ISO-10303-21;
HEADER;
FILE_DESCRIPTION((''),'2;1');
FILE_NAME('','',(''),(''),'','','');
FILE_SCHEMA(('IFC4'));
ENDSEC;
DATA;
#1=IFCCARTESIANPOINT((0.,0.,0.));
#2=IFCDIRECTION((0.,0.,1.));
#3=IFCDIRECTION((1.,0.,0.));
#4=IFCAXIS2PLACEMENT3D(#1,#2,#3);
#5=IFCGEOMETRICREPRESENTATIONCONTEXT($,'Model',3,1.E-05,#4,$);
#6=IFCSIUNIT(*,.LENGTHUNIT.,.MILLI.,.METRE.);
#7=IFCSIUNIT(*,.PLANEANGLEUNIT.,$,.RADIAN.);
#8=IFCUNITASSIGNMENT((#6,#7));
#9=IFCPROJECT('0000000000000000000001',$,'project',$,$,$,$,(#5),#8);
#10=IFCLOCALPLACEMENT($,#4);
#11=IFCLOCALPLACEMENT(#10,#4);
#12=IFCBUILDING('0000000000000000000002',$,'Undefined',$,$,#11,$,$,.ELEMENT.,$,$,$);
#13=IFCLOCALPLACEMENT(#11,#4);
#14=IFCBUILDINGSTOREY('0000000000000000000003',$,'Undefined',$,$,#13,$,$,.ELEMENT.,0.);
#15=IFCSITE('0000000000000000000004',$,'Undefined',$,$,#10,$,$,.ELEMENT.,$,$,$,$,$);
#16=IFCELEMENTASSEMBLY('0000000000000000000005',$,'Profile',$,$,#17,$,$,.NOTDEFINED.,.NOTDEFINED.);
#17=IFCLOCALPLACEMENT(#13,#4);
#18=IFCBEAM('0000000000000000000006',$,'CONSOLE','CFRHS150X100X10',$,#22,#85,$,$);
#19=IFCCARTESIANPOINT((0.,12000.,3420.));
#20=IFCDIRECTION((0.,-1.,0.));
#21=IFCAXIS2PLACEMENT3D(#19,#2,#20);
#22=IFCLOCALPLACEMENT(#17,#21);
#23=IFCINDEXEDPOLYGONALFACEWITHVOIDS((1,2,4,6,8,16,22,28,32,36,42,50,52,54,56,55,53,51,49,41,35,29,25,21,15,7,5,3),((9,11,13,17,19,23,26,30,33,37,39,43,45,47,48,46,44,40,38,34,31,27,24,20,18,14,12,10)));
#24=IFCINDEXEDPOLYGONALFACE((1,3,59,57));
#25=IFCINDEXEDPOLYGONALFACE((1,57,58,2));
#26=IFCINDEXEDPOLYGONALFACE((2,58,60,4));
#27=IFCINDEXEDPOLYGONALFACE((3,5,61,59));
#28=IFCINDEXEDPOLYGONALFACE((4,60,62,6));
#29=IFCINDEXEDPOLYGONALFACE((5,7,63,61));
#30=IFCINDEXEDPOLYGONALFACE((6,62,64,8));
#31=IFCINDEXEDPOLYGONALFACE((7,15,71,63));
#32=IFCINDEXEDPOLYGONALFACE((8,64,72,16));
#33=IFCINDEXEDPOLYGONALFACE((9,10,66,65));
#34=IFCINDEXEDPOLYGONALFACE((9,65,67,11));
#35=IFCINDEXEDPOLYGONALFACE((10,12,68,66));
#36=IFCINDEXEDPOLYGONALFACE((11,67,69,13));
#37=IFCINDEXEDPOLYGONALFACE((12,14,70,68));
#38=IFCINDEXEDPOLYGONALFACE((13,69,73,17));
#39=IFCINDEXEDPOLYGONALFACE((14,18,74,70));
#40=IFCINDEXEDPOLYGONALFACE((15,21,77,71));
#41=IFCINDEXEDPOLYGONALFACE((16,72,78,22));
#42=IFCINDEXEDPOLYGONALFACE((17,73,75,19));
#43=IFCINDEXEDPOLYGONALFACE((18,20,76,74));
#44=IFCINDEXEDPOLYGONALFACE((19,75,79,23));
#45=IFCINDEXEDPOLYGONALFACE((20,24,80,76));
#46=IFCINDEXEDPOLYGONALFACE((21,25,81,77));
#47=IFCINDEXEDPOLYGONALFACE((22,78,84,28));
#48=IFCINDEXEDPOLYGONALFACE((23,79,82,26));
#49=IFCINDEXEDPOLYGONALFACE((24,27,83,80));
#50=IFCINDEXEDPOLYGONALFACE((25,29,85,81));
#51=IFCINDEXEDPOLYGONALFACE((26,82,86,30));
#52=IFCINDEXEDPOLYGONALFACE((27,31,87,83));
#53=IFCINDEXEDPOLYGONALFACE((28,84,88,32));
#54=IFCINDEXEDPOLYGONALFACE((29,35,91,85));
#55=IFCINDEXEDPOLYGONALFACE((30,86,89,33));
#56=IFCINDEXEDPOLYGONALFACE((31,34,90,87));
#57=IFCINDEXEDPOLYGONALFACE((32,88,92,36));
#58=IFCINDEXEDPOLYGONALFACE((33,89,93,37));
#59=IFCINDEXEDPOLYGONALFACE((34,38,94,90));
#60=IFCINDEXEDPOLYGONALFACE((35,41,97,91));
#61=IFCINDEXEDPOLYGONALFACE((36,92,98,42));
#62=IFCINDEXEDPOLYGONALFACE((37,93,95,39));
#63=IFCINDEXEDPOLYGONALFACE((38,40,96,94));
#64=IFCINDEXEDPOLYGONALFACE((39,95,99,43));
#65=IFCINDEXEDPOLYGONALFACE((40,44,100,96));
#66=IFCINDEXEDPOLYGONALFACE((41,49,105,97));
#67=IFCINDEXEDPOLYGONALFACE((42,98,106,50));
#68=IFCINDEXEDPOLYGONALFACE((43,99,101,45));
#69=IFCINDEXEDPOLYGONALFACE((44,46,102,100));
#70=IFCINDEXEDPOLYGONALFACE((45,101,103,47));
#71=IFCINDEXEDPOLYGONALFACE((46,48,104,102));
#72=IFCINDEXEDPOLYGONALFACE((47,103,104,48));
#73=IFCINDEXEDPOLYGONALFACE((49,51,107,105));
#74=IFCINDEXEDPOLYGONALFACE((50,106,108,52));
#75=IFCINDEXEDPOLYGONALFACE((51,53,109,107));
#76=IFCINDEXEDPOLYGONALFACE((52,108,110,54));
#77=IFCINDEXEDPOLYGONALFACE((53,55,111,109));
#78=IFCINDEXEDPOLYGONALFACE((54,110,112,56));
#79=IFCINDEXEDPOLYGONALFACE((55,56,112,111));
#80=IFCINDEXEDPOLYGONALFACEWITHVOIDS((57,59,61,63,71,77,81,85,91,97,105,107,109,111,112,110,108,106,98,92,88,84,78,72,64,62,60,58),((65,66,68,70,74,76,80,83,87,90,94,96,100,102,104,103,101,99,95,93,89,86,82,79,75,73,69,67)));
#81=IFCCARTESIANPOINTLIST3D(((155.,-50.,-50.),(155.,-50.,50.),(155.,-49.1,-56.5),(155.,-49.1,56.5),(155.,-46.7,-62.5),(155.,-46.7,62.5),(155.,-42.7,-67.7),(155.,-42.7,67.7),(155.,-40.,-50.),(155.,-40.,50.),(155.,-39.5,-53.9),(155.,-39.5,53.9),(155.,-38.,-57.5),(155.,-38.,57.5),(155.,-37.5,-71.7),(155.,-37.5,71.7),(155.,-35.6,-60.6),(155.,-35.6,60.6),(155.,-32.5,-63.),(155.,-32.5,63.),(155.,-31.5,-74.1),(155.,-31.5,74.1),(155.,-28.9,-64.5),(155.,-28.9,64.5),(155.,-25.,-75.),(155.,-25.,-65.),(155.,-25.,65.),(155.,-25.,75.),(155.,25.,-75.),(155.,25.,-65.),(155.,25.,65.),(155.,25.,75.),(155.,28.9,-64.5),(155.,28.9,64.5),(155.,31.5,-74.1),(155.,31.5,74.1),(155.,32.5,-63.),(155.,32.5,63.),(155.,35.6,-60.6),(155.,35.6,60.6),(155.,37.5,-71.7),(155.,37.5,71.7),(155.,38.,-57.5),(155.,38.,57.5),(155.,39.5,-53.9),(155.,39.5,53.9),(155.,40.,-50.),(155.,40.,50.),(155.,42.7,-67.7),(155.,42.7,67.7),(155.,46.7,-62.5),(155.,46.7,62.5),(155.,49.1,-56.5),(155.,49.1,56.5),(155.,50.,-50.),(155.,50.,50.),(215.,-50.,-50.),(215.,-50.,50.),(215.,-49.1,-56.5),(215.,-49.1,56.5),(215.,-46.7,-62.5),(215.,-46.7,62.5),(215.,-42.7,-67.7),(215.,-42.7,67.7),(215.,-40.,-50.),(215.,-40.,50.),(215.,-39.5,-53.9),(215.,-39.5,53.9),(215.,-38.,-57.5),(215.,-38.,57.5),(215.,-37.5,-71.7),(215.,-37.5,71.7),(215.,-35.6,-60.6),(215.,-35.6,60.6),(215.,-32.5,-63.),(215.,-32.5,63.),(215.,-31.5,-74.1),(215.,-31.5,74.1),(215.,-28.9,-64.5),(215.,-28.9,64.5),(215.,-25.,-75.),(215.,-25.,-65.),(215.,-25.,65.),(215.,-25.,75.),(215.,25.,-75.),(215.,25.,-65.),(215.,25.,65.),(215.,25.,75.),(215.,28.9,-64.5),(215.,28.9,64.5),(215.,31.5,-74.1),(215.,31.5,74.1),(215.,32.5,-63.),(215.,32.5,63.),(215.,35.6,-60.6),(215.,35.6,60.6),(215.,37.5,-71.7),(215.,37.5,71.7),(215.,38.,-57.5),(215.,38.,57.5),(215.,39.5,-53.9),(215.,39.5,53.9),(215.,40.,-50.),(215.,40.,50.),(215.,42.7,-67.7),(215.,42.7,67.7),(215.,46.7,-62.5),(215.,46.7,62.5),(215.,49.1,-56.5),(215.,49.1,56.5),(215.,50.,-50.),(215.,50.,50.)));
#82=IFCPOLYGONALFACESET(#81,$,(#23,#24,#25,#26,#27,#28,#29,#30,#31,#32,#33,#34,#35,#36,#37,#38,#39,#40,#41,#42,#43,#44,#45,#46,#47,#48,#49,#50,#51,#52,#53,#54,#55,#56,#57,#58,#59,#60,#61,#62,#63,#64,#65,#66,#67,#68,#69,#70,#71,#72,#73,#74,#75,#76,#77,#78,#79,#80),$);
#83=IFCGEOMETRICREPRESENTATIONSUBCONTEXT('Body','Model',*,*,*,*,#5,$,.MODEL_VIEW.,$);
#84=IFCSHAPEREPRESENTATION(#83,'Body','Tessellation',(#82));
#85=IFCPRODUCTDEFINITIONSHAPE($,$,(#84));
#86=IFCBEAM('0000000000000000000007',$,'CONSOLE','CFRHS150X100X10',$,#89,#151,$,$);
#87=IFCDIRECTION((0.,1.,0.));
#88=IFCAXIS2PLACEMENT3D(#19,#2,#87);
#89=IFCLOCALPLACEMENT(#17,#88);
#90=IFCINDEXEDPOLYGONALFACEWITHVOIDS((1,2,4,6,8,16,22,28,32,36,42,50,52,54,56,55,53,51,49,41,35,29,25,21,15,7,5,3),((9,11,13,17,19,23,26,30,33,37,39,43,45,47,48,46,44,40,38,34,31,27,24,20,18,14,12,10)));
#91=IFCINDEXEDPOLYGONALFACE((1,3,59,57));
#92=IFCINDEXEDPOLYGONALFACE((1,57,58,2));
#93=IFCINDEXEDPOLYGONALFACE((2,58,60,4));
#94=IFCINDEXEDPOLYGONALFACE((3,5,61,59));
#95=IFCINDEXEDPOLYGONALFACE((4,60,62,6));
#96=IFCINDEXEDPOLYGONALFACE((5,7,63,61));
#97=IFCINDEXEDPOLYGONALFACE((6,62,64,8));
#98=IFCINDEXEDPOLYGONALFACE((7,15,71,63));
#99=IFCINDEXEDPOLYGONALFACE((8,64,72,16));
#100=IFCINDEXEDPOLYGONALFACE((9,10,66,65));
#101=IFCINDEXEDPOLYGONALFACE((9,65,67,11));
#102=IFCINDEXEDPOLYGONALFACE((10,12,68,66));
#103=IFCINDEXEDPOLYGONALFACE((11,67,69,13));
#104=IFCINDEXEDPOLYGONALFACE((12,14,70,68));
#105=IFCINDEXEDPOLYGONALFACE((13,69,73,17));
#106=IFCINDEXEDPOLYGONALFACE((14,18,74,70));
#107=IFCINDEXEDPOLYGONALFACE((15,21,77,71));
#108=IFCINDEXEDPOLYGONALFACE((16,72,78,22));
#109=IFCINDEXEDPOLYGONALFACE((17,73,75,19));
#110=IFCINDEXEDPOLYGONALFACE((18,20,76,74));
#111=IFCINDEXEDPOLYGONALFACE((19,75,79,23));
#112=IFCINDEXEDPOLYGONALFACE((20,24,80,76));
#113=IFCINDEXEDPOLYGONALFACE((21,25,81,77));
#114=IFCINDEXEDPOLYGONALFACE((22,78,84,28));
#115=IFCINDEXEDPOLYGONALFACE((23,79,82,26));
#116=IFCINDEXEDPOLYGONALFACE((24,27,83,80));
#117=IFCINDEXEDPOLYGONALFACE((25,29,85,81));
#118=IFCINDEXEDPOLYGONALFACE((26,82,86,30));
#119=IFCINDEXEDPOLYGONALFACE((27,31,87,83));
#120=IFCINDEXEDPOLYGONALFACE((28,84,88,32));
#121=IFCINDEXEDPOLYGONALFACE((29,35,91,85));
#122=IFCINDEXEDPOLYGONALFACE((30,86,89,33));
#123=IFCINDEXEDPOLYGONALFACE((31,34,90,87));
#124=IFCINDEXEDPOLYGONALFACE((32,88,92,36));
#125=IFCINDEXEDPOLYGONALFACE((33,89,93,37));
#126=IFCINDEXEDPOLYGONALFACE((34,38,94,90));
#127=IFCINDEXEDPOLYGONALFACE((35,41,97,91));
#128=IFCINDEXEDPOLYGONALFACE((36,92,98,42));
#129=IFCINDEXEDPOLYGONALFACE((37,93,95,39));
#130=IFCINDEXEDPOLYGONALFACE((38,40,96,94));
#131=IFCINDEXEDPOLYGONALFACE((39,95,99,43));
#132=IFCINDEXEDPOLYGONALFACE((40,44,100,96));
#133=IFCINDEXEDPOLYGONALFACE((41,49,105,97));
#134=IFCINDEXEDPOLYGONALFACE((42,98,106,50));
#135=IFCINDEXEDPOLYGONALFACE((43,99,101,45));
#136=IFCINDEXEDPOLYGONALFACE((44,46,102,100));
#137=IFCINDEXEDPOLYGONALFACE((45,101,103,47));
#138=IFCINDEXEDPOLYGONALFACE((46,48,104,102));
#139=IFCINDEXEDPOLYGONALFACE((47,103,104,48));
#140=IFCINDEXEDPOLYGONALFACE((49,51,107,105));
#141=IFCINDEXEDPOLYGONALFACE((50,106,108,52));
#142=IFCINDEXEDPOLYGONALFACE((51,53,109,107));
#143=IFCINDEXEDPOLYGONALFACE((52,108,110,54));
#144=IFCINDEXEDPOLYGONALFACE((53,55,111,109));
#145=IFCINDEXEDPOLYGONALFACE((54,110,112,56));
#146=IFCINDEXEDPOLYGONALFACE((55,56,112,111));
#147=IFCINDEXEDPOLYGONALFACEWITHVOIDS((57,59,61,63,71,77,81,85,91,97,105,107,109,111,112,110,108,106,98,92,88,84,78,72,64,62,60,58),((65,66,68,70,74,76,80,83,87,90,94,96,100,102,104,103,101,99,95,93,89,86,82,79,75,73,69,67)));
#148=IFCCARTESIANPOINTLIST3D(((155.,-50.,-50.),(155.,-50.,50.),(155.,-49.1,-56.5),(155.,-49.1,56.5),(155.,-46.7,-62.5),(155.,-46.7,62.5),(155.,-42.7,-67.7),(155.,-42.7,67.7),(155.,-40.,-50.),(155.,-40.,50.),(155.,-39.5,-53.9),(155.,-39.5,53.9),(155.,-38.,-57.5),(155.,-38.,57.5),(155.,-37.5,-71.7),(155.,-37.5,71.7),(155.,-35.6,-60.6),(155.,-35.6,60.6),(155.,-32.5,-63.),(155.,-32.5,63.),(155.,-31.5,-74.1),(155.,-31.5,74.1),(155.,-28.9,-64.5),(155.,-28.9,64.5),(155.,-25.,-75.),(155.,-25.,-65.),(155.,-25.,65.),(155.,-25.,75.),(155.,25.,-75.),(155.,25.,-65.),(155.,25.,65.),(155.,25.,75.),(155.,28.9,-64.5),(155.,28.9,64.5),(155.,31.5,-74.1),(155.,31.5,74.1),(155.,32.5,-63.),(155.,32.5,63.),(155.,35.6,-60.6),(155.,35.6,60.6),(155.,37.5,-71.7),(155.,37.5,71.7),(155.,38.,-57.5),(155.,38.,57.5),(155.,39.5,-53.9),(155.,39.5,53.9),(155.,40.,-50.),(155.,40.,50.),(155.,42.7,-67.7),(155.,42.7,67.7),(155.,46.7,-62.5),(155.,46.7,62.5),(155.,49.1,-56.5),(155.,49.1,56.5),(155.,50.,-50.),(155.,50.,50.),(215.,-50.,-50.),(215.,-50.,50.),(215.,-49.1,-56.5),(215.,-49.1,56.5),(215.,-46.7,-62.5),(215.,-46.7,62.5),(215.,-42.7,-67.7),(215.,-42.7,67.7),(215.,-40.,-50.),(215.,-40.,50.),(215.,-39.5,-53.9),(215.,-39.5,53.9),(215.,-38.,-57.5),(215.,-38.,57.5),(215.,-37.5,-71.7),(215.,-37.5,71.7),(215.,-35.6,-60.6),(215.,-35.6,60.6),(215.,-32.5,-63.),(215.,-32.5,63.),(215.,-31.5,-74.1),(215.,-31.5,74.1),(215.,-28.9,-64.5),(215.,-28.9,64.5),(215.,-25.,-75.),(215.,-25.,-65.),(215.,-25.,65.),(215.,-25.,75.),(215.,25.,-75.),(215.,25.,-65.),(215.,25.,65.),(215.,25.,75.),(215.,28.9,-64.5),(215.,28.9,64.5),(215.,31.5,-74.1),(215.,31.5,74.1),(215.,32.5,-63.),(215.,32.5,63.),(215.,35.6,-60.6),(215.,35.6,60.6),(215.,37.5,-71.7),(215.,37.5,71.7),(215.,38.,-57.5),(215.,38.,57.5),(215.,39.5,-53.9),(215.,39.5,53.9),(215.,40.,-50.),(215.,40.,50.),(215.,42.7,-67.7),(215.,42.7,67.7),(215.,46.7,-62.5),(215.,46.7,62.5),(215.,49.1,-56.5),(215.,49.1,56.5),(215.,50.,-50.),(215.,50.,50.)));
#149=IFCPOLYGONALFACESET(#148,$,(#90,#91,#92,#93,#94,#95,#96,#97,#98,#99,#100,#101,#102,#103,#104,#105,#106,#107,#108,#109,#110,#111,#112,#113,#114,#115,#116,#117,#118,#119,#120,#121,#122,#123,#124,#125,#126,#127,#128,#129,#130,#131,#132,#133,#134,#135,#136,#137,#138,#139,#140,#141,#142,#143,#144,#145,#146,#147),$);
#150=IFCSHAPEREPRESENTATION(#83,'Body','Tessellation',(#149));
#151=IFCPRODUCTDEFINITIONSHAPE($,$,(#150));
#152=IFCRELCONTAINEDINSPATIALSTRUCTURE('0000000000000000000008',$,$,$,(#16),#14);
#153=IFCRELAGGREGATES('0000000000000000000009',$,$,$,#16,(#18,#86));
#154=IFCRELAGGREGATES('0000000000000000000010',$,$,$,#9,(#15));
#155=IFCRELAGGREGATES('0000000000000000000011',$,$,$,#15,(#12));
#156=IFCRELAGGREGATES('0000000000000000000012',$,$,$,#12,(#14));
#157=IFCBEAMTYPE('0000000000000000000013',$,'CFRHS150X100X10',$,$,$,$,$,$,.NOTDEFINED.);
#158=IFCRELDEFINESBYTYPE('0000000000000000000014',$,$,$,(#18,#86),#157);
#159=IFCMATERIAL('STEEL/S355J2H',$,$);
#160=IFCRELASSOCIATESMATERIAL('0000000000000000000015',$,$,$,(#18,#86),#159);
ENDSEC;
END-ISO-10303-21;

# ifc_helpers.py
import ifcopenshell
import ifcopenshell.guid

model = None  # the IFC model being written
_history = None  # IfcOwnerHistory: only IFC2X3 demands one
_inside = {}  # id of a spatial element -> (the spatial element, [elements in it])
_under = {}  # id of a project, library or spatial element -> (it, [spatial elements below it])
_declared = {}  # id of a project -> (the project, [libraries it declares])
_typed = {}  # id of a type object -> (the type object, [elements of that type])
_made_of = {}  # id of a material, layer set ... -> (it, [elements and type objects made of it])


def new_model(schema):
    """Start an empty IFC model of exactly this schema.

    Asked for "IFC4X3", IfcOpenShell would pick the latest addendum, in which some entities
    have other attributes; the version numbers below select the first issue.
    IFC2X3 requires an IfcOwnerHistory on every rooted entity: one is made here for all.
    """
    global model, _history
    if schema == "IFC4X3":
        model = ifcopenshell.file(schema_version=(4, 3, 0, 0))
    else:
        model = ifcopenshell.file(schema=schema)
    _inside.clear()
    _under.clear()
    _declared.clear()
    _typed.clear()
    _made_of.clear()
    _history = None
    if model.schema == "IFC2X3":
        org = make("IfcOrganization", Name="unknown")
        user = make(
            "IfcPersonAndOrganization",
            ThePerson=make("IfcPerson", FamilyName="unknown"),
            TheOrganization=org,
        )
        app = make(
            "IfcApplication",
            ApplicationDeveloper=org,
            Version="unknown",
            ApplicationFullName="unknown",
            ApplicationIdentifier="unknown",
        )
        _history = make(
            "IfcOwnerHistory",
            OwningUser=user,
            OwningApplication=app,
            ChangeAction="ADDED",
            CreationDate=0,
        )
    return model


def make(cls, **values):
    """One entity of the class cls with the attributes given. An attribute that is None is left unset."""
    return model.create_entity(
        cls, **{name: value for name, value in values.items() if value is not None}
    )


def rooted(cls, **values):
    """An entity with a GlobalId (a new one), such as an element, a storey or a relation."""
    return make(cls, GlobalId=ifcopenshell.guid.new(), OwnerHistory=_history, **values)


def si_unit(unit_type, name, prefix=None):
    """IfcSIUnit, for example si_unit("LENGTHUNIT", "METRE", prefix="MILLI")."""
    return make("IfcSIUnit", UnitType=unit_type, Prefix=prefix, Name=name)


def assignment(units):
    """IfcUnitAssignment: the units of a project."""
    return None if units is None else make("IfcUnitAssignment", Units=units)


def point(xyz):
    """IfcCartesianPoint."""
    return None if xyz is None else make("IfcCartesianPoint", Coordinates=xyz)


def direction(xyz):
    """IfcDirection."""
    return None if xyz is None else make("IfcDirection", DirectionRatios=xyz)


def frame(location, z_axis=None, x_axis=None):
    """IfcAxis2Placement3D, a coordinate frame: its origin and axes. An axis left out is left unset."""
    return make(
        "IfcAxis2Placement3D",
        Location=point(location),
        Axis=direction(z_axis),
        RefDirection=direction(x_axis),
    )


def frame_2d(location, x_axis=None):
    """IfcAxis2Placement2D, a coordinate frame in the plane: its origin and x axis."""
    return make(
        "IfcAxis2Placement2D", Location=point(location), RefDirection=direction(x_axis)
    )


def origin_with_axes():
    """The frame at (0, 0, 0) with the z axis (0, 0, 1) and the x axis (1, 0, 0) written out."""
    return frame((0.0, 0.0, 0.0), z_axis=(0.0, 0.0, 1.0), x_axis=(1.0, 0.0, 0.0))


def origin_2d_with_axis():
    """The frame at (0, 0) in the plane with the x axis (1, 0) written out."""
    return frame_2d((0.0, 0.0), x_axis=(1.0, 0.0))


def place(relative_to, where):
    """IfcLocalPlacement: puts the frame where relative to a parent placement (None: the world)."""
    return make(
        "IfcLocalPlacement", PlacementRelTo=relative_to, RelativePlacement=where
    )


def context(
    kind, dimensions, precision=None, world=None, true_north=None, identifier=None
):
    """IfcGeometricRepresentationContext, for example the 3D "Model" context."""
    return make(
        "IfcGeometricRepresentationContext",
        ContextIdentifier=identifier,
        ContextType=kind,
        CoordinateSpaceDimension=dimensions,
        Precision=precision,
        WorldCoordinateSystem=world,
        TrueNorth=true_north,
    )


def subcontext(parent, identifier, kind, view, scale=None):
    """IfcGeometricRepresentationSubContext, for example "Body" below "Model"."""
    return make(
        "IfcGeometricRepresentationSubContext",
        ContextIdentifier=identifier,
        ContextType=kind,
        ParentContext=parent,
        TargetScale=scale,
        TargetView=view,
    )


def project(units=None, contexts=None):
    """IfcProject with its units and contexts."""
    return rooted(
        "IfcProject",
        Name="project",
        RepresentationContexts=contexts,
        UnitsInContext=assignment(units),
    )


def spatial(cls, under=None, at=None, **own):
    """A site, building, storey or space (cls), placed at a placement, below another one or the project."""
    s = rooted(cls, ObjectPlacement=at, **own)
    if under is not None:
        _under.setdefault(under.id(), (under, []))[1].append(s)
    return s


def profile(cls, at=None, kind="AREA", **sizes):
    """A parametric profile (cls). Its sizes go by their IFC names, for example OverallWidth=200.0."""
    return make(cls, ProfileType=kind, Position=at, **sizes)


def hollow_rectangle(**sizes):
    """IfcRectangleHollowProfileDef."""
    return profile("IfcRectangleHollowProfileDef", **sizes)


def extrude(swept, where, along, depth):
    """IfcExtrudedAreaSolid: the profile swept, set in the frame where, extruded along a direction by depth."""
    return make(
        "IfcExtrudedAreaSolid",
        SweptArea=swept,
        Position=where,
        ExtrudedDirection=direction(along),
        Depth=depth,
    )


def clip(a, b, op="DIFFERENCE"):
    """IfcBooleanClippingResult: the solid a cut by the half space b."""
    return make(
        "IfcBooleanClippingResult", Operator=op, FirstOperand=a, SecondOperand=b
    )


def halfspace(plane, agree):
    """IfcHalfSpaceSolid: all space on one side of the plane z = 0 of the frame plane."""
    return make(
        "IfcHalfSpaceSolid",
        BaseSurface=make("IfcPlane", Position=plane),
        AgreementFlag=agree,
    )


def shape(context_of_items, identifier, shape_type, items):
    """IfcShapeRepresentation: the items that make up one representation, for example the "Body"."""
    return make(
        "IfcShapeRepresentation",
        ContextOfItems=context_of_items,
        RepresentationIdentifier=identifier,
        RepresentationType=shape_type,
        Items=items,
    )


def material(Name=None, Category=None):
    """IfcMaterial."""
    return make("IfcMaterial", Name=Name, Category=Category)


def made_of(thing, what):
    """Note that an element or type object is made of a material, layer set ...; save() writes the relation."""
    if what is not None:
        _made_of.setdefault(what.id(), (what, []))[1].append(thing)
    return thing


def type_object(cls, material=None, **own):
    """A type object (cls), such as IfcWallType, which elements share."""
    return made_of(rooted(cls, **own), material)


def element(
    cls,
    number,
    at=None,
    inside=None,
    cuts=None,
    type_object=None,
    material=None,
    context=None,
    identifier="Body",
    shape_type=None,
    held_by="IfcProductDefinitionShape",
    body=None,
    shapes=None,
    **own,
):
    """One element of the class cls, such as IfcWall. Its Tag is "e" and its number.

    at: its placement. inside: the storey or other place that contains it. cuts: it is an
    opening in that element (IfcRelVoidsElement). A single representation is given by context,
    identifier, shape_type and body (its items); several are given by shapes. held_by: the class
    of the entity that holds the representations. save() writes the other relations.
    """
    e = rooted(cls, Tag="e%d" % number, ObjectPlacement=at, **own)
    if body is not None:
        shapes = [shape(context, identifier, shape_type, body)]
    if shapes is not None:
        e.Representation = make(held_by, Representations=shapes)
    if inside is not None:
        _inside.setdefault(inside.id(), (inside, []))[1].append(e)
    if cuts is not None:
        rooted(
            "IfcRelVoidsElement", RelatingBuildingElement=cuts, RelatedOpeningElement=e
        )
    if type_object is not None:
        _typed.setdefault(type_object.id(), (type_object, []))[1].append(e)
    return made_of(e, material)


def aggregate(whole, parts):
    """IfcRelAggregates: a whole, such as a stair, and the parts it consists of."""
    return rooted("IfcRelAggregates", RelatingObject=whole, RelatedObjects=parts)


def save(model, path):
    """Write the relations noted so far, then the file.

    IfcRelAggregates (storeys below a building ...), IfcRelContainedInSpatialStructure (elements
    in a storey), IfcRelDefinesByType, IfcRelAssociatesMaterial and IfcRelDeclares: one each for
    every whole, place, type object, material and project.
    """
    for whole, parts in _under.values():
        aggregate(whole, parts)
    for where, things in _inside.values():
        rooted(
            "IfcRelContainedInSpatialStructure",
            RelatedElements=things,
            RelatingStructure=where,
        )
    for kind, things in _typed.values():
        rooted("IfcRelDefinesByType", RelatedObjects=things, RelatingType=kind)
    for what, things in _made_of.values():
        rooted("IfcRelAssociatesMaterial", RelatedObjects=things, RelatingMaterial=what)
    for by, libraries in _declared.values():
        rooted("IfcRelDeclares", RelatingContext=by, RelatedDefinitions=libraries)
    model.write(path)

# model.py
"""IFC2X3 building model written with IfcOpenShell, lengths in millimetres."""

from ifc_helpers import new_model, si_unit, frame, origin_with_axes, origin_2d_with_axis, place, context, subcontext, project, spatial, hollow_rectangle, extrude, clip, halfspace, material, type_object, element, aggregate, save


model = new_model("IFC2X3")

# Units and contexts
model_context = context("Model", 3, precision=1e-05, world=origin_with_axes())
body_context = subcontext(model_context, "Body", "Model", "MODEL_VIEW")
ifc_project = project(units=[si_unit("LENGTHUNIT", "METRE", prefix="MILLI"), si_unit("PLANEANGLEUNIT", "RADIAN")], contexts=[model_context])

# Site, building, storey
site_placement = place(None, origin_with_axes())
site = spatial("IfcSite", under=ifc_project, at=site_placement, Name="Undefined", CompositionType="ELEMENT")
building_placement = place(site_placement, origin_with_axes())
building = spatial("IfcBuilding", under=site, at=building_placement, Name="Undefined", CompositionType="ELEMENT")
storey_placement = place(building_placement, origin_with_axes())
storey = spatial("IfcBuildingStorey", under=building, at=storey_placement, Name="Undefined", CompositionType="ELEMENT", Elevation=0.0)

# Element assembly
assembly_1_placement = place(storey_placement, origin_with_axes())
assembly_1 = element("IfcElementAssembly", 1, at=assembly_1_placement, inside=storey, Name="Profile", AssemblyPlace="NOTDEFINED", PredefinedType="NOTDEFINED")
ifc_material_1 = material(Name="STEEL/S355J2H")

# Beams
beam_type_1 = type_object("IfcBeamType", Name="CFRHS150X100X10", PredefinedType="NOTDEFINED")
beam_1_placement = place(assembly_1_placement, frame((0.0, 12000.0, 3420.0), z_axis=(0.0, 0.0, 1.0), x_axis=(0.0, -1.0, 0.0)))
beam_1 = element("IfcBeam", 2, at=beam_1_placement, type_object=beam_type_1, material=ifc_material_1, Name="CONSOLE", Description="CFRHS150X100X10", context=body_context, shape_type="Clipping", body=[
    clip(extrude(hollow_rectangle(XDim=100.0, YDim=150.0, WallThickness=10.0, InnerFilletRadius=15.0, OuterFilletRadius=25.0, at=origin_2d_with_axis()), frame((215.0, 0.0, 0.0), z_axis=(-1.0, 0.0, 0.0), x_axis=(0.0, -1.0, 0.0)), (0.0, 0.0, 1.0), 215.0), halfspace(frame((155.0, 50.0, -75.0), z_axis=(-1.0, 0.0, 0.0), x_axis=(0.0, 0.0, 1.0)), False)),
])
beam_2_placement = place(assembly_1_placement, frame((0.0, 12000.0, 3420.0), z_axis=(0.0, 0.0, 1.0), x_axis=(0.0, 1.0, 0.0)))
beam_2 = element("IfcBeam", 3, at=beam_2_placement, type_object=beam_type_1, material=ifc_material_1, Name="CONSOLE", Description="CFRHS150X100X10", context=body_context, shape_type="Clipping", body=[
    clip(extrude(hollow_rectangle(XDim=100.0, YDim=150.0, WallThickness=10.0, InnerFilletRadius=15.0, OuterFilletRadius=25.0, at=origin_2d_with_axis()), frame((215.0, 0.0, 0.0), z_axis=(-1.0, 0.0, 0.0), x_axis=(0.0, -1.0, 0.0)), (0.0, 0.0, 1.0), 215.0), halfspace(frame((155.0, 50.0, -75.0), z_axis=(-1.0, 0.0, 0.0), x_axis=(0.0, 0.0, 1.0)), False)),
])

aggregate(assembly_1, [beam_1, beam_2])

save(model, "model.ifc")
